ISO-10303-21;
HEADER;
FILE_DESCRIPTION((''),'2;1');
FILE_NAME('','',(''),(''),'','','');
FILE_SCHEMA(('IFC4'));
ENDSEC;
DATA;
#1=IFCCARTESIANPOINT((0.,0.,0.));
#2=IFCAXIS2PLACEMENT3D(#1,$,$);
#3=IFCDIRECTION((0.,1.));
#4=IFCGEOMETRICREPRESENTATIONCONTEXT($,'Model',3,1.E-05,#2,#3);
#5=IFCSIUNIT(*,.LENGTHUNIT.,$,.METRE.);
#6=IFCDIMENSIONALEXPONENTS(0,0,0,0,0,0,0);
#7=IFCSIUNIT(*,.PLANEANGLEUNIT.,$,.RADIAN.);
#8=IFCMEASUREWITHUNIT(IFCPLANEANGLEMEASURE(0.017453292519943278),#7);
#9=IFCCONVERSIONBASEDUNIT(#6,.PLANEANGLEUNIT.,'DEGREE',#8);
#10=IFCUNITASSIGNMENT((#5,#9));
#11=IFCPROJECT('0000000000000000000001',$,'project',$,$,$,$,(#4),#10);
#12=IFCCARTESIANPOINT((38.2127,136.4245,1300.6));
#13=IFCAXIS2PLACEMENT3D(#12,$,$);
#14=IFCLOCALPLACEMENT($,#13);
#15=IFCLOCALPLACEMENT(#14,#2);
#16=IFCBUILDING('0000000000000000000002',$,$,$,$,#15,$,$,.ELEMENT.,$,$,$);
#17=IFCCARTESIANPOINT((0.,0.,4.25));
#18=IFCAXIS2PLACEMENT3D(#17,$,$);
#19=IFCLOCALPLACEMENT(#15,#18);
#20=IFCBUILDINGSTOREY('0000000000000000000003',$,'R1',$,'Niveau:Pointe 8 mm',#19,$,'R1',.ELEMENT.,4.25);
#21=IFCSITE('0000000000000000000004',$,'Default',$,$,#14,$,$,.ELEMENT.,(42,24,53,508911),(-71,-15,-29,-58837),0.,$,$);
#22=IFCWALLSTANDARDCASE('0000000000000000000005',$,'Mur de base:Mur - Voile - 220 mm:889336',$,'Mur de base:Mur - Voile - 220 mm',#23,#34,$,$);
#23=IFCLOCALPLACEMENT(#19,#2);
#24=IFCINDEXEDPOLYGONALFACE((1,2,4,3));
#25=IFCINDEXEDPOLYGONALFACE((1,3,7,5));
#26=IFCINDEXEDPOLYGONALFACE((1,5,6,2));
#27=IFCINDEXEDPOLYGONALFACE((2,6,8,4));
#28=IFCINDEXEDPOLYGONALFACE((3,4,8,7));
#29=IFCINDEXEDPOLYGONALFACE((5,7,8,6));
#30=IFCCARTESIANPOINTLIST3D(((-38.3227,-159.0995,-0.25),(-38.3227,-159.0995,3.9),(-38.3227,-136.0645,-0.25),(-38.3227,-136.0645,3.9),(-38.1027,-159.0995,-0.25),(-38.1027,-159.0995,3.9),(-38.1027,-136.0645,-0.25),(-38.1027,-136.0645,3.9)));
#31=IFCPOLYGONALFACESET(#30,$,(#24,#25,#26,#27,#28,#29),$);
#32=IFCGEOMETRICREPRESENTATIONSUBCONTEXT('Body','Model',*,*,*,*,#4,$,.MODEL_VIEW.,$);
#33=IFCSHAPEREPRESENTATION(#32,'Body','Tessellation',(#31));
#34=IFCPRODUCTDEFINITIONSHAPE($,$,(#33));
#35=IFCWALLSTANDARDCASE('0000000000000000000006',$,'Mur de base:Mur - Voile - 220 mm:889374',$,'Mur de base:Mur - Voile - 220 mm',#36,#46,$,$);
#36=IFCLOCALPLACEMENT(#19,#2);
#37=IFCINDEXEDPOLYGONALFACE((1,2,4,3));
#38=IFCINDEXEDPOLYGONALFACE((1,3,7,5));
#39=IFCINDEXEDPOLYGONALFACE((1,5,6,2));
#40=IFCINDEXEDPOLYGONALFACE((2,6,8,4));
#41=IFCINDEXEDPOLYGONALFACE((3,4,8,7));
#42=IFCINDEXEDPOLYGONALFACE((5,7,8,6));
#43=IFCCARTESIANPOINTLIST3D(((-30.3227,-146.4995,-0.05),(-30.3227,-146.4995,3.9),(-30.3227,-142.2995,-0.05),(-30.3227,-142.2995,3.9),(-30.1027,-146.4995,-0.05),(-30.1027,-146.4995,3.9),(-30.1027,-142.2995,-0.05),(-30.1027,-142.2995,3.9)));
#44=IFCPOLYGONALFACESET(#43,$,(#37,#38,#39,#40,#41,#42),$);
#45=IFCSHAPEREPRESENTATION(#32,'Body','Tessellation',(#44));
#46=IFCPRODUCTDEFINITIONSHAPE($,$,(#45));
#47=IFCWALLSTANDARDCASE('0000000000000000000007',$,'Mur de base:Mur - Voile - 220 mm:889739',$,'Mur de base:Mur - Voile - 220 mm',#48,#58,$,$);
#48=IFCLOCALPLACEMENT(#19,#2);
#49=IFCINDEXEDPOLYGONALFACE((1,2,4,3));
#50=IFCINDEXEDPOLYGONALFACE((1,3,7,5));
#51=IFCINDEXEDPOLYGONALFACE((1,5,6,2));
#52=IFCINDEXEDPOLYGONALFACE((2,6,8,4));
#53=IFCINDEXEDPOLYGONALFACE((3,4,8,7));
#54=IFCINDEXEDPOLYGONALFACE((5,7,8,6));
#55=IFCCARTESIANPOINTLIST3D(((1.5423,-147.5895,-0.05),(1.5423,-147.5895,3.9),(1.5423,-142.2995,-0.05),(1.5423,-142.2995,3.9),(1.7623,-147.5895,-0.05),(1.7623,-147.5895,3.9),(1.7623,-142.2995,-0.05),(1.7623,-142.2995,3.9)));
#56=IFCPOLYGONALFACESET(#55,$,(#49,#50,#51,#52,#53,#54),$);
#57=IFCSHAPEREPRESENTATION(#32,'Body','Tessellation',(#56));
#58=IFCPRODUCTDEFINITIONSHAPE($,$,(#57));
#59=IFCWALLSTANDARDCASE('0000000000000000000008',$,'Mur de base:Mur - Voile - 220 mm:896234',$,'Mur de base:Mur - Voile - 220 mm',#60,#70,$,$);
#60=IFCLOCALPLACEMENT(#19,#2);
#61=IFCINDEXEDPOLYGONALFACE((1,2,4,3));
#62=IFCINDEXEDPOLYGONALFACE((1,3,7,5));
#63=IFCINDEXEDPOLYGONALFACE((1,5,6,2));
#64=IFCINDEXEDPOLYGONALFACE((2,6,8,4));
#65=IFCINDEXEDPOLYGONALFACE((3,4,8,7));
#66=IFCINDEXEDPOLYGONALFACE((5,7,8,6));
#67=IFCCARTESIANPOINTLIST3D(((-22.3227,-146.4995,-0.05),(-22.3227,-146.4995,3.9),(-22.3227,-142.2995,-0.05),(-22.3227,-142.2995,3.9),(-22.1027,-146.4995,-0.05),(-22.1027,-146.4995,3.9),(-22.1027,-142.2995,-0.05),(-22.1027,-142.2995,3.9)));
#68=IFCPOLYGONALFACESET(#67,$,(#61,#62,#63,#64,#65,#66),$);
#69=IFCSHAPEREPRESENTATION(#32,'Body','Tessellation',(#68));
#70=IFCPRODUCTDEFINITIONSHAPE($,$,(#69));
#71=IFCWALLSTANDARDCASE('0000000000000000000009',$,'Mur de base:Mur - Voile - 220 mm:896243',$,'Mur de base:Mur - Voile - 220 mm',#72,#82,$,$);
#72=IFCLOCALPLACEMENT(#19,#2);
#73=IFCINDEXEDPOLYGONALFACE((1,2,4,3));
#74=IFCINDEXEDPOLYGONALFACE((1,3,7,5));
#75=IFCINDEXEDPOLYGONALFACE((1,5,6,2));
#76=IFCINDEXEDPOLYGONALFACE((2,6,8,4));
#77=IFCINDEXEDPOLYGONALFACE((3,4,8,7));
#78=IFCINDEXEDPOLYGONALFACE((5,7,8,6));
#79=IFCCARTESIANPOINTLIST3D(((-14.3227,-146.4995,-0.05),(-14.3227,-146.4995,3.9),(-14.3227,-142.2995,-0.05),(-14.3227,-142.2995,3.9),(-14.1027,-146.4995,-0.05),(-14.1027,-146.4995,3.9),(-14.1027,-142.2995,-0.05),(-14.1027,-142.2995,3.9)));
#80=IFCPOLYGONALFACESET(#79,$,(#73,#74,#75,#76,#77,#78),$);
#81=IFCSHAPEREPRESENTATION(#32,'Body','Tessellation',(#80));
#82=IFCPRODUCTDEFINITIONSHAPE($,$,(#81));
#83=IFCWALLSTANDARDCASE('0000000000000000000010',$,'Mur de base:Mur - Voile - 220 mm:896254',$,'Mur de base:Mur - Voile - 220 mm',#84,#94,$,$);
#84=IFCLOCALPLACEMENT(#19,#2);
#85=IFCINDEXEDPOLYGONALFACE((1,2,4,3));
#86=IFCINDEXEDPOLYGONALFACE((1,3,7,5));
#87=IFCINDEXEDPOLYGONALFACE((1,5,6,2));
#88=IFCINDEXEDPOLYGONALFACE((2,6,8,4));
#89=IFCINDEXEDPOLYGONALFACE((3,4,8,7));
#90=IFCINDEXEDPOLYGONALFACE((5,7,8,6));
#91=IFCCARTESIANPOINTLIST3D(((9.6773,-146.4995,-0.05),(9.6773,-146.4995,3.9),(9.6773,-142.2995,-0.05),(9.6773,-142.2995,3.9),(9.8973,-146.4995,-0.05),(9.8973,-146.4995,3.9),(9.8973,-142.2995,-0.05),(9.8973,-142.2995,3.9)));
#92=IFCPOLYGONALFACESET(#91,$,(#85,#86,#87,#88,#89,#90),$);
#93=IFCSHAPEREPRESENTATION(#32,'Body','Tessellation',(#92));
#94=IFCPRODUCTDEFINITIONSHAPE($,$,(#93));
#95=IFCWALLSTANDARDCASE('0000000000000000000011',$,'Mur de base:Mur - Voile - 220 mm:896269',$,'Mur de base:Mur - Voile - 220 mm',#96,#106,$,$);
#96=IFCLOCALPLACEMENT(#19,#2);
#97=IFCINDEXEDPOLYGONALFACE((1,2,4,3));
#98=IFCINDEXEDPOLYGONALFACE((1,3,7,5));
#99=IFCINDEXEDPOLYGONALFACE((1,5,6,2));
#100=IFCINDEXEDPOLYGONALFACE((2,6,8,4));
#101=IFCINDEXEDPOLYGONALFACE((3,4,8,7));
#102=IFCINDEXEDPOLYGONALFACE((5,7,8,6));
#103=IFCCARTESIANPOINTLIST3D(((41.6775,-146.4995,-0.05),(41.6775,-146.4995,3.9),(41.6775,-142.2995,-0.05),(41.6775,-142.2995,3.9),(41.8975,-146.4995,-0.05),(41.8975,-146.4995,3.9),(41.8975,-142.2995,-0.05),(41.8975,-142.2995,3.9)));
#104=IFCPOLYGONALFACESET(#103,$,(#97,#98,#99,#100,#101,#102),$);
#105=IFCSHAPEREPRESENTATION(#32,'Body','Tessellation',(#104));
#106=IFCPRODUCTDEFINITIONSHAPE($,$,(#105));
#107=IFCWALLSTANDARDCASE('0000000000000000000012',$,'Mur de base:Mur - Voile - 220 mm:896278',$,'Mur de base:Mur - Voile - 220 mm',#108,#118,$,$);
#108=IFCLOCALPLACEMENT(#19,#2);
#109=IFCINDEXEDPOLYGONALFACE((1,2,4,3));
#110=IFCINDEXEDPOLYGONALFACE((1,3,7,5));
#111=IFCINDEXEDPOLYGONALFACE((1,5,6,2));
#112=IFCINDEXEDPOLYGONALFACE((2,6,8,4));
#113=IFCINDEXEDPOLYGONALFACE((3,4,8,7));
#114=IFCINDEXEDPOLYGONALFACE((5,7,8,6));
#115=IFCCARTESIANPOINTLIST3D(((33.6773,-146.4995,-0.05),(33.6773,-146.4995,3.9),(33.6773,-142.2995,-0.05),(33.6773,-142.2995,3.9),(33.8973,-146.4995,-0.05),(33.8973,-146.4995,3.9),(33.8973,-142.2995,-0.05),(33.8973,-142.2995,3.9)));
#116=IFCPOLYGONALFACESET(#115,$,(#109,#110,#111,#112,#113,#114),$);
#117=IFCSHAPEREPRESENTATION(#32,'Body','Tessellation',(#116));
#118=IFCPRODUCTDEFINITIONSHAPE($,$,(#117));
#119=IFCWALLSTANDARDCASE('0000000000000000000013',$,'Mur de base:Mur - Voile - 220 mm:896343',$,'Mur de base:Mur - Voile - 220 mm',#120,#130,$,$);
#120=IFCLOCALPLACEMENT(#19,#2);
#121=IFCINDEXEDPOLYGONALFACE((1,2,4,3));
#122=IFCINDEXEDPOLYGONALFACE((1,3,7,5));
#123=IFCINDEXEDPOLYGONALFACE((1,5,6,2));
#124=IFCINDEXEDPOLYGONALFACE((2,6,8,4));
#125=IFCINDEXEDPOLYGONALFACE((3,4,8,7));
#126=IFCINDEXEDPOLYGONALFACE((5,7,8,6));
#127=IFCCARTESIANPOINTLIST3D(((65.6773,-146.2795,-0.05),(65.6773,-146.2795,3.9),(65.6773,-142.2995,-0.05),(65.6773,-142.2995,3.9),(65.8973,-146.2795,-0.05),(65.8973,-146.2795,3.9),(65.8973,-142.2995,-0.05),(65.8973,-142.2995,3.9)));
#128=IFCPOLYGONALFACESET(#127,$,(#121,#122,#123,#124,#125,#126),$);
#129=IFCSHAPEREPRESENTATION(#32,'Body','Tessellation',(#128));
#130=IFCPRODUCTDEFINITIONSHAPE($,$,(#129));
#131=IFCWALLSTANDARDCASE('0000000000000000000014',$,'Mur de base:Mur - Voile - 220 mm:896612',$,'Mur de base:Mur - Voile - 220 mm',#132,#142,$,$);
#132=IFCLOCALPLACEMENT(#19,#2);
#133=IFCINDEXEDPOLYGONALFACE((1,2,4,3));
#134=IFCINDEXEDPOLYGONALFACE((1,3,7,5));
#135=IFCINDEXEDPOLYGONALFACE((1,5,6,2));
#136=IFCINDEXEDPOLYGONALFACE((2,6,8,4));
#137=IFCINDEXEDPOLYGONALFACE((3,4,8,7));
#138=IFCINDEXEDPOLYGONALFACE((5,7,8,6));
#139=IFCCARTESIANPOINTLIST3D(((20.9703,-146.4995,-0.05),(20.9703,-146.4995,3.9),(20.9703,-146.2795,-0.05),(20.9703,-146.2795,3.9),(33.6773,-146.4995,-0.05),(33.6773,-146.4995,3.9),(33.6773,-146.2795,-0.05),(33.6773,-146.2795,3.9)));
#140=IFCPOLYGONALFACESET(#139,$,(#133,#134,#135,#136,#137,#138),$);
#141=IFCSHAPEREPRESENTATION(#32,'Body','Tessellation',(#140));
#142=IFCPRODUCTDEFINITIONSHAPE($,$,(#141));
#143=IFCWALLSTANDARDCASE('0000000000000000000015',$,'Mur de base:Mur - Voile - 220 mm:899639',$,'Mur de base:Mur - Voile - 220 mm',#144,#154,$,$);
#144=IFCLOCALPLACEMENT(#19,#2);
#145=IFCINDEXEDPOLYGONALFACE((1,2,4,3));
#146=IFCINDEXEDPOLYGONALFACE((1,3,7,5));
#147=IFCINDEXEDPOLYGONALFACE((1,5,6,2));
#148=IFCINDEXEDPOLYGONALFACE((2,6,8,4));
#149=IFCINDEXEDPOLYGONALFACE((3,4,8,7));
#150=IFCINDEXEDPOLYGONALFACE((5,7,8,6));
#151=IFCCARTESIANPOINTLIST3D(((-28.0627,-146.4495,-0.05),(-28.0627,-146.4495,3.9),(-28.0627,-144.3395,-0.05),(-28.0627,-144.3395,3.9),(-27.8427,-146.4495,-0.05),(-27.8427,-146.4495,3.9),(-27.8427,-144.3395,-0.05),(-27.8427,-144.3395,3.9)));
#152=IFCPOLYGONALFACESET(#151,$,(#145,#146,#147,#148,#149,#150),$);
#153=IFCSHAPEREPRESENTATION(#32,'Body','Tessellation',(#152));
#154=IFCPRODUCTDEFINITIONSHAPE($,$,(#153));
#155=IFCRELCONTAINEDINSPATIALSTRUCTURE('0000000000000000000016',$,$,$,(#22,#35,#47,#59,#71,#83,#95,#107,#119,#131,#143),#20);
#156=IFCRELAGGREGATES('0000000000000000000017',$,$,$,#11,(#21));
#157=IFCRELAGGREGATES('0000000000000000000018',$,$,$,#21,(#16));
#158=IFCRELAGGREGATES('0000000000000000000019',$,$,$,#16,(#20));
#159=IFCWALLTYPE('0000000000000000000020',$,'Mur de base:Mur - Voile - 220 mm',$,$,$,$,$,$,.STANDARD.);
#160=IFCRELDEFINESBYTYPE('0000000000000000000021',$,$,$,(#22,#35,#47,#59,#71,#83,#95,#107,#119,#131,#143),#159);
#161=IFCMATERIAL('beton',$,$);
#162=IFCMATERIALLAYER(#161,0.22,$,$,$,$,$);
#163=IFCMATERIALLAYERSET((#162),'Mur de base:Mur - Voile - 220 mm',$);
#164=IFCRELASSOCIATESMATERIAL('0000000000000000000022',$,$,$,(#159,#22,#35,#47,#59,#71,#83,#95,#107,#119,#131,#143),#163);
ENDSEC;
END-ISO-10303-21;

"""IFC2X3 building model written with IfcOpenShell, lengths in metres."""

from ifc_helpers import new_model, entity, si_unit, converted_unit, direction, frame, frame_2d, origin, place, context, subcontext, project, spatial, polyline, rectangle, extrude, clip, bounded_halfspace, material, layer, layer_set, layer_usage, type_object, element, save


model = new_model("IFC2X3")

# Units and contexts
model_context = context("Model", 3, precision=1e-05, world=origin(), true_north=direction((0.0, 1.0)))
body_context = subcontext(model_context, "Body", "Model", "MODEL_VIEW")
ifc_project = project(units=[si_unit("LENGTHUNIT", "METRE"), converted_unit("PLANEANGLEUNIT", "DEGREE", entity("IfcPlaneAngleMeasure", 0.017453292519943278), si_unit("PLANEANGLEUNIT", "RADIAN"), dimensions=[0, 0, 0, 0, 0, 0, 0])], contexts=[model_context])

# Site, building, storey
site_placement = place(None, frame((38.2127, 136.4245, 1300.6)))
site = spatial("IfcSite", under=ifc_project, at=site_placement, Name="Default", CompositionType="ELEMENT", RefLatitude=(42, 24, 53, 508911), RefLongitude=(-71, -15, -29, -58837), RefElevation=0.0)
building_placement = place(site_placement, origin())
building = spatial("IfcBuilding", under=site, at=building_placement, CompositionType="ELEMENT")
storey_placement = place(building_placement, frame((0.0, 0.0, 4.25)))
storey = spatial("IfcBuildingStorey", under=building, at=storey_placement, Name="R1", ObjectType="Niveau:Pointe 8 mm", LongName="R1", CompositionType="ELEMENT", Elevation=4.25)

# Walls
ifc_material_1 = material(Name="beton")
ifc_layer_1 = layer(ifc_material_1, 0.22)
ifc_layer_set_1 = layer_set([ifc_layer_1], Name="Mur de base:Mur - Voile - 220 mm")
wall_type = type_object("IfcWallType", Name="Mur de base:Mur - Voile - 220 mm", PredefinedType="STANDARD", material=ifc_layer_set_1)
ifc_layer_usage_1 = layer_usage(ifc_layer_set_1, "AXIS2", "NEGATIVE", 0.11)
wall_1_placement = place(storey_placement, frame((-38.2127, -136.0645, -0.25), z_axis=(0.0, 0.0, 1.0), x_axis=(0.0, -1.0, 0.0)))
element("IfcWallStandardCase", 1, at=wall_1_placement, inside=storey, type_object=wall_type, material=ifc_layer_usage_1, Name="Mur de base:Mur - Voile - 220 mm:889336", ObjectType="Mur de base:Mur - Voile - 220 mm", context=body_context, shape_type="SweptSolid", body=[
    extrude(rectangle(XDim=23.035, YDim=0.22, at=frame_2d((11.5175, 0.0), x_axis=(-1.0, 0.0))), origin(), (0.0, 0.0, 1.0), 4.15),
])
ifc_layer_usage_2 = layer_usage(ifc_layer_set_1, "AXIS2", "NEGATIVE", 0.11)
wall_2_placement = place(storey_placement, frame((-30.2127, -142.2995, -0.05), z_axis=(0.0, 0.0, 1.0), x_axis=(0.0, -1.0, 0.0)))
element("IfcWallStandardCase", 2, at=wall_2_placement, inside=storey, type_object=wall_type, material=ifc_layer_usage_2, Name="Mur de base:Mur - Voile - 220 mm:889374", ObjectType="Mur de base:Mur - Voile - 220 mm", context=body_context, shape_type="Clipping", body=[
    clip(extrude(rectangle(XDim=4.2, YDim=0.22, at=frame_2d((2.1, 0.0), x_axis=(-1.0, 0.0))), origin(), (0.0, 0.0, 1.0), 3.95), bounded_halfspace(frame((0.0, -0.11, 3.95), z_axis=(0.0, 0.0, -1.0), x_axis=(0.0, 1.0, 0.0)), True, frame((0.0, -0.11, 3.95)), polyline([(0.0, 0.0), (4.2, 0.0), (4.2, 0.22), (0.0, 0.22), (0.0, 0.0)]))),
])
ifc_layer_usage_3 = layer_usage(ifc_layer_set_1, "AXIS2", "NEGATIVE", 0.11)
wall_3_placement = place(storey_placement, frame((1.6523, -142.2995, -0.05), z_axis=(0.0, 0.0, 1.0), x_axis=(0.0, -1.0, 0.0)))
element("IfcWallStandardCase", 3, at=wall_3_placement, inside=storey, type_object=wall_type, material=ifc_layer_usage_3, Name="Mur de base:Mur - Voile - 220 mm:889739", ObjectType="Mur de base:Mur - Voile - 220 mm", context=body_context, shape_type="Clipping", body=[
    clip(extrude(rectangle(XDim=5.29, YDim=0.22, at=frame_2d((2.645, 0.0), x_axis=(-1.0, 0.0))), origin(), (0.0, 0.0, 1.0), 3.95), bounded_halfspace(frame((0.0, -0.11, 3.95), z_axis=(0.0, 0.0, -1.0), x_axis=(0.0, 1.0, 0.0)), True, frame((0.0, -0.11, 3.95)), polyline([(0.0, 0.0), (3.98, 0.0), (4.2, 0.0), (5.29, 0.0), (5.29, 0.22), (0.0, 0.22), (0.0, 0.0)]))),
])
ifc_layer_usage_4 = layer_usage(ifc_layer_set_1, "AXIS2", "NEGATIVE", 0.11)
wall_4_placement = place(storey_placement, frame((-22.2127, -142.2995, -0.05), z_axis=(0.0, 0.0, 1.0), x_axis=(0.0, -1.0, 0.0)))
element("IfcWallStandardCase", 4, at=wall_4_placement, inside=storey, type_object=wall_type, material=ifc_layer_usage_4, Name="Mur de base:Mur - Voile - 220 mm:896234", ObjectType="Mur de base:Mur - Voile - 220 mm", context=body_context, shape_type="Clipping", body=[
    clip(extrude(rectangle(XDim=4.2, YDim=0.22, at=frame_2d((2.1, 0.0), x_axis=(-1.0, 0.0))), origin(), (0.0, 0.0, 1.0), 3.95), bounded_halfspace(frame((0.0, -0.11, 3.95), z_axis=(0.0, 0.0, -1.0), x_axis=(0.0, 1.0, 0.0)), True, frame((0.0, -0.11, 3.95)), polyline([(0.0, 0.0), (4.2, 0.0), (4.2, 0.22), (0.0, 0.22), (0.0, 0.0)]))),
])
ifc_layer_usage_5 = layer_usage(ifc_layer_set_1, "AXIS2", "NEGATIVE", 0.11)
wall_5_placement = place(storey_placement, frame((-14.2127, -142.2995, -0.05), z_axis=(0.0, 0.0, 1.0), x_axis=(0.0, -1.0, 0.0)))
element("IfcWallStandardCase", 5, at=wall_5_placement, inside=storey, type_object=wall_type, material=ifc_layer_usage_5, Name="Mur de base:Mur - Voile - 220 mm:896243", ObjectType="Mur de base:Mur - Voile - 220 mm", context=body_context, shape_type="Clipping", body=[
    clip(extrude(rectangle(XDim=4.2, YDim=0.22, at=frame_2d((2.1, 0.0), x_axis=(-1.0, 0.0))), origin(), (0.0, 0.0, 1.0), 3.95), bounded_halfspace(frame((0.0, -0.11, 3.95), z_axis=(0.0, 0.0, -1.0), x_axis=(0.0, 1.0, 0.0)), True, frame((0.0, -0.11, 3.95)), polyline([(0.0, 0.0), (4.2, 0.0), (4.2, 0.22), (3.98, 0.22), (0.0, 0.22), (0.0, 0.0)]))),
])
ifc_layer_usage_6 = layer_usage(ifc_layer_set_1, "AXIS2", "NEGATIVE", 0.11)
wall_6_placement = place(storey_placement, frame((9.7873, -142.2995, -0.05), z_axis=(0.0, 0.0, 1.0), x_axis=(0.0, -1.0, 0.0)))
element("IfcWallStandardCase", 6, at=wall_6_placement, inside=storey, type_object=wall_type, material=ifc_layer_usage_6, Name="Mur de base:Mur - Voile - 220 mm:896254", ObjectType="Mur de base:Mur - Voile - 220 mm", context=body_context, shape_type="Clipping", body=[
    clip(extrude(rectangle(XDim=4.2, YDim=0.22, at=frame_2d((2.1, 0.0), x_axis=(-1.0, 0.0))), origin(), (0.0, 0.0, 1.0), 3.95), bounded_halfspace(frame((0.0, -0.11, 3.95), z_axis=(0.0, 0.0, -1.0), x_axis=(0.0, 1.0, 0.0)), True, frame((0.0, -0.11, 3.95)), polyline([(0.0, 0.0), (4.2, 0.0), (4.2, 0.22), (3.98, 0.22), (0.0, 0.22), (0.0, 0.0)]))),
])
ifc_layer_usage_7 = layer_usage(ifc_layer_set_1, "AXIS2", "NEGATIVE", 0.11)
wall_7_placement = place(storey_placement, frame((41.7875, -142.2995, -0.05), z_axis=(0.0, 0.0, 1.0), x_axis=(0.0, -1.0, 0.0)))
element("IfcWallStandardCase", 7, at=wall_7_placement, inside=storey, type_object=wall_type, material=ifc_layer_usage_7, Name="Mur de base:Mur - Voile - 220 mm:896269", ObjectType="Mur de base:Mur - Voile - 220 mm", context=body_context, shape_type="Clipping", body=[
    clip(extrude(rectangle(XDim=4.2, YDim=0.22, at=frame_2d((2.1, 0.0), x_axis=(-1.0, 0.0))), origin(), (0.0, 0.0, 1.0), 3.95), bounded_halfspace(frame((0.0, -0.11, 3.95), z_axis=(0.0, 0.0, -1.0), x_axis=(0.0, 1.0, 0.0)), True, frame((0.0, -0.11, 3.95)), polyline([(0.0, 0.0), (4.2, 0.0), (4.2, 0.22), (3.98, 0.22), (0.0, 0.22), (0.0, 0.0)]))),
])
ifc_layer_usage_8 = layer_usage(ifc_layer_set_1, "AXIS2", "NEGATIVE", 0.11)
wall_8_placement = place(storey_placement, frame((33.7873, -142.2995, -0.05), z_axis=(0.0, 0.0, 1.0), x_axis=(0.0, -1.0, 0.0)))
element("IfcWallStandardCase", 8, at=wall_8_placement, inside=storey, type_object=wall_type, material=ifc_layer_usage_8, Name="Mur de base:Mur - Voile - 220 mm:896278", ObjectType="Mur de base:Mur - Voile - 220 mm", context=body_context, shape_type="Clipping", body=[
    clip(extrude(rectangle(XDim=4.2, YDim=0.22, at=frame_2d((2.1, 0.0), x_axis=(-1.0, 0.0))), origin(), (0.0, 0.0, 1.0), 3.95), bounded_halfspace(frame((0.0, -0.11, 3.95), z_axis=(0.0, 0.0, -1.0), x_axis=(0.0, 1.0, 0.0)), True, frame((0.0, -0.11, 3.95)), polyline([(0.0, 0.0), (3.98, 0.0), (4.2, 0.0), (4.2, 0.22), (3.98, 0.22), (0.0, 0.22), (0.0, 0.0)]))),
])
ifc_layer_usage_9 = layer_usage(ifc_layer_set_1, "AXIS2", "NEGATIVE", 0.11)
wall_9_placement = place(storey_placement, frame((65.7873, -142.2995, -0.05), z_axis=(0.0, 0.0, 1.0), x_axis=(0.0, -1.0, 0.0)))
element("IfcWallStandardCase", 9, at=wall_9_placement, inside=storey, type_object=wall_type, material=ifc_layer_usage_9, Name="Mur de base:Mur - Voile - 220 mm:896343", ObjectType="Mur de base:Mur - Voile - 220 mm", context=body_context, shape_type="Clipping", body=[
    clip(extrude(rectangle(XDim=3.98, YDim=0.22, at=frame_2d((1.99, 0.0), x_axis=(-1.0, 0.0))), origin(), (0.0, 0.0, 1.0), 3.95), bounded_halfspace(frame((0.0, -0.11, 3.95), z_axis=(0.0, 0.0, -1.0), x_axis=(0.0, 1.0, 0.0)), True, frame((0.0, -0.11, 3.95)), polyline([(0.0, 0.0), (3.98, 0.0), (3.98, 0.22), (0.0, 0.22), (0.0, 0.0)]))),
])
ifc_layer_usage_10 = layer_usage(ifc_layer_set_1, "AXIS2", "NEGATIVE", 0.11)
wall_10_placement = place(storey_placement, frame((20.9703, -146.3895, -0.05)))
element("IfcWallStandardCase", 10, at=wall_10_placement, inside=storey, type_object=wall_type, material=ifc_layer_usage_10, Name="Mur de base:Mur - Voile - 220 mm:896612", ObjectType="Mur de base:Mur - Voile - 220 mm", context=body_context, shape_type="Clipping", body=[
    clip(extrude(rectangle(XDim=12.707, YDim=0.22, at=frame_2d((6.3535, 0.0), x_axis=(-1.0, 0.0))), origin(), (0.0, 0.0, 1.0), 3.95), bounded_halfspace(frame((0.0, -0.11, 3.95), z_axis=(0.0, 0.0, -1.0), x_axis=(1.0, 0.0, 0.0)), True, frame((0.0, -0.11, 3.95)), polyline([(0.0, 0.0), (12.707, 0.0), (12.707, 0.22), (0.0, 0.22), (0.0, 0.0)]))),
])
ifc_layer_usage_11 = layer_usage(ifc_layer_set_1, "AXIS2", "NEGATIVE", 0.11)
wall_11_placement = place(storey_placement, frame((-27.9527, -144.3395, -0.05), z_axis=(0.0, 0.0, 1.0), x_axis=(0.0, -1.0, 0.0)))
element("IfcWallStandardCase", 11, at=wall_11_placement, inside=storey, type_object=wall_type, material=ifc_layer_usage_11, Name="Mur de base:Mur - Voile - 220 mm:899639", ObjectType="Mur de base:Mur - Voile - 220 mm", context=body_context, shape_type="Clipping", body=[
    clip(extrude(rectangle(XDim=2.11, YDim=0.22, at=frame_2d((1.055, 0.0), x_axis=(-1.0, 0.0))), origin(), (0.0, 0.0, 1.0), 3.95), bounded_halfspace(frame((0.0, -0.11, 3.95), z_axis=(0.0, 0.0, -1.0), x_axis=(0.0, 1.0, 0.0)), True, frame((0.0, -0.11, 3.95)), polyline([(0.0, 0.0), (1.94, 0.0), (2.11, 0.0), (2.11, 0.22), (1.94, 0.22), (0.22, 0.22), (0.0, 0.22), (0.0, 0.0)]))),
])

save(model, "model.ifc")
